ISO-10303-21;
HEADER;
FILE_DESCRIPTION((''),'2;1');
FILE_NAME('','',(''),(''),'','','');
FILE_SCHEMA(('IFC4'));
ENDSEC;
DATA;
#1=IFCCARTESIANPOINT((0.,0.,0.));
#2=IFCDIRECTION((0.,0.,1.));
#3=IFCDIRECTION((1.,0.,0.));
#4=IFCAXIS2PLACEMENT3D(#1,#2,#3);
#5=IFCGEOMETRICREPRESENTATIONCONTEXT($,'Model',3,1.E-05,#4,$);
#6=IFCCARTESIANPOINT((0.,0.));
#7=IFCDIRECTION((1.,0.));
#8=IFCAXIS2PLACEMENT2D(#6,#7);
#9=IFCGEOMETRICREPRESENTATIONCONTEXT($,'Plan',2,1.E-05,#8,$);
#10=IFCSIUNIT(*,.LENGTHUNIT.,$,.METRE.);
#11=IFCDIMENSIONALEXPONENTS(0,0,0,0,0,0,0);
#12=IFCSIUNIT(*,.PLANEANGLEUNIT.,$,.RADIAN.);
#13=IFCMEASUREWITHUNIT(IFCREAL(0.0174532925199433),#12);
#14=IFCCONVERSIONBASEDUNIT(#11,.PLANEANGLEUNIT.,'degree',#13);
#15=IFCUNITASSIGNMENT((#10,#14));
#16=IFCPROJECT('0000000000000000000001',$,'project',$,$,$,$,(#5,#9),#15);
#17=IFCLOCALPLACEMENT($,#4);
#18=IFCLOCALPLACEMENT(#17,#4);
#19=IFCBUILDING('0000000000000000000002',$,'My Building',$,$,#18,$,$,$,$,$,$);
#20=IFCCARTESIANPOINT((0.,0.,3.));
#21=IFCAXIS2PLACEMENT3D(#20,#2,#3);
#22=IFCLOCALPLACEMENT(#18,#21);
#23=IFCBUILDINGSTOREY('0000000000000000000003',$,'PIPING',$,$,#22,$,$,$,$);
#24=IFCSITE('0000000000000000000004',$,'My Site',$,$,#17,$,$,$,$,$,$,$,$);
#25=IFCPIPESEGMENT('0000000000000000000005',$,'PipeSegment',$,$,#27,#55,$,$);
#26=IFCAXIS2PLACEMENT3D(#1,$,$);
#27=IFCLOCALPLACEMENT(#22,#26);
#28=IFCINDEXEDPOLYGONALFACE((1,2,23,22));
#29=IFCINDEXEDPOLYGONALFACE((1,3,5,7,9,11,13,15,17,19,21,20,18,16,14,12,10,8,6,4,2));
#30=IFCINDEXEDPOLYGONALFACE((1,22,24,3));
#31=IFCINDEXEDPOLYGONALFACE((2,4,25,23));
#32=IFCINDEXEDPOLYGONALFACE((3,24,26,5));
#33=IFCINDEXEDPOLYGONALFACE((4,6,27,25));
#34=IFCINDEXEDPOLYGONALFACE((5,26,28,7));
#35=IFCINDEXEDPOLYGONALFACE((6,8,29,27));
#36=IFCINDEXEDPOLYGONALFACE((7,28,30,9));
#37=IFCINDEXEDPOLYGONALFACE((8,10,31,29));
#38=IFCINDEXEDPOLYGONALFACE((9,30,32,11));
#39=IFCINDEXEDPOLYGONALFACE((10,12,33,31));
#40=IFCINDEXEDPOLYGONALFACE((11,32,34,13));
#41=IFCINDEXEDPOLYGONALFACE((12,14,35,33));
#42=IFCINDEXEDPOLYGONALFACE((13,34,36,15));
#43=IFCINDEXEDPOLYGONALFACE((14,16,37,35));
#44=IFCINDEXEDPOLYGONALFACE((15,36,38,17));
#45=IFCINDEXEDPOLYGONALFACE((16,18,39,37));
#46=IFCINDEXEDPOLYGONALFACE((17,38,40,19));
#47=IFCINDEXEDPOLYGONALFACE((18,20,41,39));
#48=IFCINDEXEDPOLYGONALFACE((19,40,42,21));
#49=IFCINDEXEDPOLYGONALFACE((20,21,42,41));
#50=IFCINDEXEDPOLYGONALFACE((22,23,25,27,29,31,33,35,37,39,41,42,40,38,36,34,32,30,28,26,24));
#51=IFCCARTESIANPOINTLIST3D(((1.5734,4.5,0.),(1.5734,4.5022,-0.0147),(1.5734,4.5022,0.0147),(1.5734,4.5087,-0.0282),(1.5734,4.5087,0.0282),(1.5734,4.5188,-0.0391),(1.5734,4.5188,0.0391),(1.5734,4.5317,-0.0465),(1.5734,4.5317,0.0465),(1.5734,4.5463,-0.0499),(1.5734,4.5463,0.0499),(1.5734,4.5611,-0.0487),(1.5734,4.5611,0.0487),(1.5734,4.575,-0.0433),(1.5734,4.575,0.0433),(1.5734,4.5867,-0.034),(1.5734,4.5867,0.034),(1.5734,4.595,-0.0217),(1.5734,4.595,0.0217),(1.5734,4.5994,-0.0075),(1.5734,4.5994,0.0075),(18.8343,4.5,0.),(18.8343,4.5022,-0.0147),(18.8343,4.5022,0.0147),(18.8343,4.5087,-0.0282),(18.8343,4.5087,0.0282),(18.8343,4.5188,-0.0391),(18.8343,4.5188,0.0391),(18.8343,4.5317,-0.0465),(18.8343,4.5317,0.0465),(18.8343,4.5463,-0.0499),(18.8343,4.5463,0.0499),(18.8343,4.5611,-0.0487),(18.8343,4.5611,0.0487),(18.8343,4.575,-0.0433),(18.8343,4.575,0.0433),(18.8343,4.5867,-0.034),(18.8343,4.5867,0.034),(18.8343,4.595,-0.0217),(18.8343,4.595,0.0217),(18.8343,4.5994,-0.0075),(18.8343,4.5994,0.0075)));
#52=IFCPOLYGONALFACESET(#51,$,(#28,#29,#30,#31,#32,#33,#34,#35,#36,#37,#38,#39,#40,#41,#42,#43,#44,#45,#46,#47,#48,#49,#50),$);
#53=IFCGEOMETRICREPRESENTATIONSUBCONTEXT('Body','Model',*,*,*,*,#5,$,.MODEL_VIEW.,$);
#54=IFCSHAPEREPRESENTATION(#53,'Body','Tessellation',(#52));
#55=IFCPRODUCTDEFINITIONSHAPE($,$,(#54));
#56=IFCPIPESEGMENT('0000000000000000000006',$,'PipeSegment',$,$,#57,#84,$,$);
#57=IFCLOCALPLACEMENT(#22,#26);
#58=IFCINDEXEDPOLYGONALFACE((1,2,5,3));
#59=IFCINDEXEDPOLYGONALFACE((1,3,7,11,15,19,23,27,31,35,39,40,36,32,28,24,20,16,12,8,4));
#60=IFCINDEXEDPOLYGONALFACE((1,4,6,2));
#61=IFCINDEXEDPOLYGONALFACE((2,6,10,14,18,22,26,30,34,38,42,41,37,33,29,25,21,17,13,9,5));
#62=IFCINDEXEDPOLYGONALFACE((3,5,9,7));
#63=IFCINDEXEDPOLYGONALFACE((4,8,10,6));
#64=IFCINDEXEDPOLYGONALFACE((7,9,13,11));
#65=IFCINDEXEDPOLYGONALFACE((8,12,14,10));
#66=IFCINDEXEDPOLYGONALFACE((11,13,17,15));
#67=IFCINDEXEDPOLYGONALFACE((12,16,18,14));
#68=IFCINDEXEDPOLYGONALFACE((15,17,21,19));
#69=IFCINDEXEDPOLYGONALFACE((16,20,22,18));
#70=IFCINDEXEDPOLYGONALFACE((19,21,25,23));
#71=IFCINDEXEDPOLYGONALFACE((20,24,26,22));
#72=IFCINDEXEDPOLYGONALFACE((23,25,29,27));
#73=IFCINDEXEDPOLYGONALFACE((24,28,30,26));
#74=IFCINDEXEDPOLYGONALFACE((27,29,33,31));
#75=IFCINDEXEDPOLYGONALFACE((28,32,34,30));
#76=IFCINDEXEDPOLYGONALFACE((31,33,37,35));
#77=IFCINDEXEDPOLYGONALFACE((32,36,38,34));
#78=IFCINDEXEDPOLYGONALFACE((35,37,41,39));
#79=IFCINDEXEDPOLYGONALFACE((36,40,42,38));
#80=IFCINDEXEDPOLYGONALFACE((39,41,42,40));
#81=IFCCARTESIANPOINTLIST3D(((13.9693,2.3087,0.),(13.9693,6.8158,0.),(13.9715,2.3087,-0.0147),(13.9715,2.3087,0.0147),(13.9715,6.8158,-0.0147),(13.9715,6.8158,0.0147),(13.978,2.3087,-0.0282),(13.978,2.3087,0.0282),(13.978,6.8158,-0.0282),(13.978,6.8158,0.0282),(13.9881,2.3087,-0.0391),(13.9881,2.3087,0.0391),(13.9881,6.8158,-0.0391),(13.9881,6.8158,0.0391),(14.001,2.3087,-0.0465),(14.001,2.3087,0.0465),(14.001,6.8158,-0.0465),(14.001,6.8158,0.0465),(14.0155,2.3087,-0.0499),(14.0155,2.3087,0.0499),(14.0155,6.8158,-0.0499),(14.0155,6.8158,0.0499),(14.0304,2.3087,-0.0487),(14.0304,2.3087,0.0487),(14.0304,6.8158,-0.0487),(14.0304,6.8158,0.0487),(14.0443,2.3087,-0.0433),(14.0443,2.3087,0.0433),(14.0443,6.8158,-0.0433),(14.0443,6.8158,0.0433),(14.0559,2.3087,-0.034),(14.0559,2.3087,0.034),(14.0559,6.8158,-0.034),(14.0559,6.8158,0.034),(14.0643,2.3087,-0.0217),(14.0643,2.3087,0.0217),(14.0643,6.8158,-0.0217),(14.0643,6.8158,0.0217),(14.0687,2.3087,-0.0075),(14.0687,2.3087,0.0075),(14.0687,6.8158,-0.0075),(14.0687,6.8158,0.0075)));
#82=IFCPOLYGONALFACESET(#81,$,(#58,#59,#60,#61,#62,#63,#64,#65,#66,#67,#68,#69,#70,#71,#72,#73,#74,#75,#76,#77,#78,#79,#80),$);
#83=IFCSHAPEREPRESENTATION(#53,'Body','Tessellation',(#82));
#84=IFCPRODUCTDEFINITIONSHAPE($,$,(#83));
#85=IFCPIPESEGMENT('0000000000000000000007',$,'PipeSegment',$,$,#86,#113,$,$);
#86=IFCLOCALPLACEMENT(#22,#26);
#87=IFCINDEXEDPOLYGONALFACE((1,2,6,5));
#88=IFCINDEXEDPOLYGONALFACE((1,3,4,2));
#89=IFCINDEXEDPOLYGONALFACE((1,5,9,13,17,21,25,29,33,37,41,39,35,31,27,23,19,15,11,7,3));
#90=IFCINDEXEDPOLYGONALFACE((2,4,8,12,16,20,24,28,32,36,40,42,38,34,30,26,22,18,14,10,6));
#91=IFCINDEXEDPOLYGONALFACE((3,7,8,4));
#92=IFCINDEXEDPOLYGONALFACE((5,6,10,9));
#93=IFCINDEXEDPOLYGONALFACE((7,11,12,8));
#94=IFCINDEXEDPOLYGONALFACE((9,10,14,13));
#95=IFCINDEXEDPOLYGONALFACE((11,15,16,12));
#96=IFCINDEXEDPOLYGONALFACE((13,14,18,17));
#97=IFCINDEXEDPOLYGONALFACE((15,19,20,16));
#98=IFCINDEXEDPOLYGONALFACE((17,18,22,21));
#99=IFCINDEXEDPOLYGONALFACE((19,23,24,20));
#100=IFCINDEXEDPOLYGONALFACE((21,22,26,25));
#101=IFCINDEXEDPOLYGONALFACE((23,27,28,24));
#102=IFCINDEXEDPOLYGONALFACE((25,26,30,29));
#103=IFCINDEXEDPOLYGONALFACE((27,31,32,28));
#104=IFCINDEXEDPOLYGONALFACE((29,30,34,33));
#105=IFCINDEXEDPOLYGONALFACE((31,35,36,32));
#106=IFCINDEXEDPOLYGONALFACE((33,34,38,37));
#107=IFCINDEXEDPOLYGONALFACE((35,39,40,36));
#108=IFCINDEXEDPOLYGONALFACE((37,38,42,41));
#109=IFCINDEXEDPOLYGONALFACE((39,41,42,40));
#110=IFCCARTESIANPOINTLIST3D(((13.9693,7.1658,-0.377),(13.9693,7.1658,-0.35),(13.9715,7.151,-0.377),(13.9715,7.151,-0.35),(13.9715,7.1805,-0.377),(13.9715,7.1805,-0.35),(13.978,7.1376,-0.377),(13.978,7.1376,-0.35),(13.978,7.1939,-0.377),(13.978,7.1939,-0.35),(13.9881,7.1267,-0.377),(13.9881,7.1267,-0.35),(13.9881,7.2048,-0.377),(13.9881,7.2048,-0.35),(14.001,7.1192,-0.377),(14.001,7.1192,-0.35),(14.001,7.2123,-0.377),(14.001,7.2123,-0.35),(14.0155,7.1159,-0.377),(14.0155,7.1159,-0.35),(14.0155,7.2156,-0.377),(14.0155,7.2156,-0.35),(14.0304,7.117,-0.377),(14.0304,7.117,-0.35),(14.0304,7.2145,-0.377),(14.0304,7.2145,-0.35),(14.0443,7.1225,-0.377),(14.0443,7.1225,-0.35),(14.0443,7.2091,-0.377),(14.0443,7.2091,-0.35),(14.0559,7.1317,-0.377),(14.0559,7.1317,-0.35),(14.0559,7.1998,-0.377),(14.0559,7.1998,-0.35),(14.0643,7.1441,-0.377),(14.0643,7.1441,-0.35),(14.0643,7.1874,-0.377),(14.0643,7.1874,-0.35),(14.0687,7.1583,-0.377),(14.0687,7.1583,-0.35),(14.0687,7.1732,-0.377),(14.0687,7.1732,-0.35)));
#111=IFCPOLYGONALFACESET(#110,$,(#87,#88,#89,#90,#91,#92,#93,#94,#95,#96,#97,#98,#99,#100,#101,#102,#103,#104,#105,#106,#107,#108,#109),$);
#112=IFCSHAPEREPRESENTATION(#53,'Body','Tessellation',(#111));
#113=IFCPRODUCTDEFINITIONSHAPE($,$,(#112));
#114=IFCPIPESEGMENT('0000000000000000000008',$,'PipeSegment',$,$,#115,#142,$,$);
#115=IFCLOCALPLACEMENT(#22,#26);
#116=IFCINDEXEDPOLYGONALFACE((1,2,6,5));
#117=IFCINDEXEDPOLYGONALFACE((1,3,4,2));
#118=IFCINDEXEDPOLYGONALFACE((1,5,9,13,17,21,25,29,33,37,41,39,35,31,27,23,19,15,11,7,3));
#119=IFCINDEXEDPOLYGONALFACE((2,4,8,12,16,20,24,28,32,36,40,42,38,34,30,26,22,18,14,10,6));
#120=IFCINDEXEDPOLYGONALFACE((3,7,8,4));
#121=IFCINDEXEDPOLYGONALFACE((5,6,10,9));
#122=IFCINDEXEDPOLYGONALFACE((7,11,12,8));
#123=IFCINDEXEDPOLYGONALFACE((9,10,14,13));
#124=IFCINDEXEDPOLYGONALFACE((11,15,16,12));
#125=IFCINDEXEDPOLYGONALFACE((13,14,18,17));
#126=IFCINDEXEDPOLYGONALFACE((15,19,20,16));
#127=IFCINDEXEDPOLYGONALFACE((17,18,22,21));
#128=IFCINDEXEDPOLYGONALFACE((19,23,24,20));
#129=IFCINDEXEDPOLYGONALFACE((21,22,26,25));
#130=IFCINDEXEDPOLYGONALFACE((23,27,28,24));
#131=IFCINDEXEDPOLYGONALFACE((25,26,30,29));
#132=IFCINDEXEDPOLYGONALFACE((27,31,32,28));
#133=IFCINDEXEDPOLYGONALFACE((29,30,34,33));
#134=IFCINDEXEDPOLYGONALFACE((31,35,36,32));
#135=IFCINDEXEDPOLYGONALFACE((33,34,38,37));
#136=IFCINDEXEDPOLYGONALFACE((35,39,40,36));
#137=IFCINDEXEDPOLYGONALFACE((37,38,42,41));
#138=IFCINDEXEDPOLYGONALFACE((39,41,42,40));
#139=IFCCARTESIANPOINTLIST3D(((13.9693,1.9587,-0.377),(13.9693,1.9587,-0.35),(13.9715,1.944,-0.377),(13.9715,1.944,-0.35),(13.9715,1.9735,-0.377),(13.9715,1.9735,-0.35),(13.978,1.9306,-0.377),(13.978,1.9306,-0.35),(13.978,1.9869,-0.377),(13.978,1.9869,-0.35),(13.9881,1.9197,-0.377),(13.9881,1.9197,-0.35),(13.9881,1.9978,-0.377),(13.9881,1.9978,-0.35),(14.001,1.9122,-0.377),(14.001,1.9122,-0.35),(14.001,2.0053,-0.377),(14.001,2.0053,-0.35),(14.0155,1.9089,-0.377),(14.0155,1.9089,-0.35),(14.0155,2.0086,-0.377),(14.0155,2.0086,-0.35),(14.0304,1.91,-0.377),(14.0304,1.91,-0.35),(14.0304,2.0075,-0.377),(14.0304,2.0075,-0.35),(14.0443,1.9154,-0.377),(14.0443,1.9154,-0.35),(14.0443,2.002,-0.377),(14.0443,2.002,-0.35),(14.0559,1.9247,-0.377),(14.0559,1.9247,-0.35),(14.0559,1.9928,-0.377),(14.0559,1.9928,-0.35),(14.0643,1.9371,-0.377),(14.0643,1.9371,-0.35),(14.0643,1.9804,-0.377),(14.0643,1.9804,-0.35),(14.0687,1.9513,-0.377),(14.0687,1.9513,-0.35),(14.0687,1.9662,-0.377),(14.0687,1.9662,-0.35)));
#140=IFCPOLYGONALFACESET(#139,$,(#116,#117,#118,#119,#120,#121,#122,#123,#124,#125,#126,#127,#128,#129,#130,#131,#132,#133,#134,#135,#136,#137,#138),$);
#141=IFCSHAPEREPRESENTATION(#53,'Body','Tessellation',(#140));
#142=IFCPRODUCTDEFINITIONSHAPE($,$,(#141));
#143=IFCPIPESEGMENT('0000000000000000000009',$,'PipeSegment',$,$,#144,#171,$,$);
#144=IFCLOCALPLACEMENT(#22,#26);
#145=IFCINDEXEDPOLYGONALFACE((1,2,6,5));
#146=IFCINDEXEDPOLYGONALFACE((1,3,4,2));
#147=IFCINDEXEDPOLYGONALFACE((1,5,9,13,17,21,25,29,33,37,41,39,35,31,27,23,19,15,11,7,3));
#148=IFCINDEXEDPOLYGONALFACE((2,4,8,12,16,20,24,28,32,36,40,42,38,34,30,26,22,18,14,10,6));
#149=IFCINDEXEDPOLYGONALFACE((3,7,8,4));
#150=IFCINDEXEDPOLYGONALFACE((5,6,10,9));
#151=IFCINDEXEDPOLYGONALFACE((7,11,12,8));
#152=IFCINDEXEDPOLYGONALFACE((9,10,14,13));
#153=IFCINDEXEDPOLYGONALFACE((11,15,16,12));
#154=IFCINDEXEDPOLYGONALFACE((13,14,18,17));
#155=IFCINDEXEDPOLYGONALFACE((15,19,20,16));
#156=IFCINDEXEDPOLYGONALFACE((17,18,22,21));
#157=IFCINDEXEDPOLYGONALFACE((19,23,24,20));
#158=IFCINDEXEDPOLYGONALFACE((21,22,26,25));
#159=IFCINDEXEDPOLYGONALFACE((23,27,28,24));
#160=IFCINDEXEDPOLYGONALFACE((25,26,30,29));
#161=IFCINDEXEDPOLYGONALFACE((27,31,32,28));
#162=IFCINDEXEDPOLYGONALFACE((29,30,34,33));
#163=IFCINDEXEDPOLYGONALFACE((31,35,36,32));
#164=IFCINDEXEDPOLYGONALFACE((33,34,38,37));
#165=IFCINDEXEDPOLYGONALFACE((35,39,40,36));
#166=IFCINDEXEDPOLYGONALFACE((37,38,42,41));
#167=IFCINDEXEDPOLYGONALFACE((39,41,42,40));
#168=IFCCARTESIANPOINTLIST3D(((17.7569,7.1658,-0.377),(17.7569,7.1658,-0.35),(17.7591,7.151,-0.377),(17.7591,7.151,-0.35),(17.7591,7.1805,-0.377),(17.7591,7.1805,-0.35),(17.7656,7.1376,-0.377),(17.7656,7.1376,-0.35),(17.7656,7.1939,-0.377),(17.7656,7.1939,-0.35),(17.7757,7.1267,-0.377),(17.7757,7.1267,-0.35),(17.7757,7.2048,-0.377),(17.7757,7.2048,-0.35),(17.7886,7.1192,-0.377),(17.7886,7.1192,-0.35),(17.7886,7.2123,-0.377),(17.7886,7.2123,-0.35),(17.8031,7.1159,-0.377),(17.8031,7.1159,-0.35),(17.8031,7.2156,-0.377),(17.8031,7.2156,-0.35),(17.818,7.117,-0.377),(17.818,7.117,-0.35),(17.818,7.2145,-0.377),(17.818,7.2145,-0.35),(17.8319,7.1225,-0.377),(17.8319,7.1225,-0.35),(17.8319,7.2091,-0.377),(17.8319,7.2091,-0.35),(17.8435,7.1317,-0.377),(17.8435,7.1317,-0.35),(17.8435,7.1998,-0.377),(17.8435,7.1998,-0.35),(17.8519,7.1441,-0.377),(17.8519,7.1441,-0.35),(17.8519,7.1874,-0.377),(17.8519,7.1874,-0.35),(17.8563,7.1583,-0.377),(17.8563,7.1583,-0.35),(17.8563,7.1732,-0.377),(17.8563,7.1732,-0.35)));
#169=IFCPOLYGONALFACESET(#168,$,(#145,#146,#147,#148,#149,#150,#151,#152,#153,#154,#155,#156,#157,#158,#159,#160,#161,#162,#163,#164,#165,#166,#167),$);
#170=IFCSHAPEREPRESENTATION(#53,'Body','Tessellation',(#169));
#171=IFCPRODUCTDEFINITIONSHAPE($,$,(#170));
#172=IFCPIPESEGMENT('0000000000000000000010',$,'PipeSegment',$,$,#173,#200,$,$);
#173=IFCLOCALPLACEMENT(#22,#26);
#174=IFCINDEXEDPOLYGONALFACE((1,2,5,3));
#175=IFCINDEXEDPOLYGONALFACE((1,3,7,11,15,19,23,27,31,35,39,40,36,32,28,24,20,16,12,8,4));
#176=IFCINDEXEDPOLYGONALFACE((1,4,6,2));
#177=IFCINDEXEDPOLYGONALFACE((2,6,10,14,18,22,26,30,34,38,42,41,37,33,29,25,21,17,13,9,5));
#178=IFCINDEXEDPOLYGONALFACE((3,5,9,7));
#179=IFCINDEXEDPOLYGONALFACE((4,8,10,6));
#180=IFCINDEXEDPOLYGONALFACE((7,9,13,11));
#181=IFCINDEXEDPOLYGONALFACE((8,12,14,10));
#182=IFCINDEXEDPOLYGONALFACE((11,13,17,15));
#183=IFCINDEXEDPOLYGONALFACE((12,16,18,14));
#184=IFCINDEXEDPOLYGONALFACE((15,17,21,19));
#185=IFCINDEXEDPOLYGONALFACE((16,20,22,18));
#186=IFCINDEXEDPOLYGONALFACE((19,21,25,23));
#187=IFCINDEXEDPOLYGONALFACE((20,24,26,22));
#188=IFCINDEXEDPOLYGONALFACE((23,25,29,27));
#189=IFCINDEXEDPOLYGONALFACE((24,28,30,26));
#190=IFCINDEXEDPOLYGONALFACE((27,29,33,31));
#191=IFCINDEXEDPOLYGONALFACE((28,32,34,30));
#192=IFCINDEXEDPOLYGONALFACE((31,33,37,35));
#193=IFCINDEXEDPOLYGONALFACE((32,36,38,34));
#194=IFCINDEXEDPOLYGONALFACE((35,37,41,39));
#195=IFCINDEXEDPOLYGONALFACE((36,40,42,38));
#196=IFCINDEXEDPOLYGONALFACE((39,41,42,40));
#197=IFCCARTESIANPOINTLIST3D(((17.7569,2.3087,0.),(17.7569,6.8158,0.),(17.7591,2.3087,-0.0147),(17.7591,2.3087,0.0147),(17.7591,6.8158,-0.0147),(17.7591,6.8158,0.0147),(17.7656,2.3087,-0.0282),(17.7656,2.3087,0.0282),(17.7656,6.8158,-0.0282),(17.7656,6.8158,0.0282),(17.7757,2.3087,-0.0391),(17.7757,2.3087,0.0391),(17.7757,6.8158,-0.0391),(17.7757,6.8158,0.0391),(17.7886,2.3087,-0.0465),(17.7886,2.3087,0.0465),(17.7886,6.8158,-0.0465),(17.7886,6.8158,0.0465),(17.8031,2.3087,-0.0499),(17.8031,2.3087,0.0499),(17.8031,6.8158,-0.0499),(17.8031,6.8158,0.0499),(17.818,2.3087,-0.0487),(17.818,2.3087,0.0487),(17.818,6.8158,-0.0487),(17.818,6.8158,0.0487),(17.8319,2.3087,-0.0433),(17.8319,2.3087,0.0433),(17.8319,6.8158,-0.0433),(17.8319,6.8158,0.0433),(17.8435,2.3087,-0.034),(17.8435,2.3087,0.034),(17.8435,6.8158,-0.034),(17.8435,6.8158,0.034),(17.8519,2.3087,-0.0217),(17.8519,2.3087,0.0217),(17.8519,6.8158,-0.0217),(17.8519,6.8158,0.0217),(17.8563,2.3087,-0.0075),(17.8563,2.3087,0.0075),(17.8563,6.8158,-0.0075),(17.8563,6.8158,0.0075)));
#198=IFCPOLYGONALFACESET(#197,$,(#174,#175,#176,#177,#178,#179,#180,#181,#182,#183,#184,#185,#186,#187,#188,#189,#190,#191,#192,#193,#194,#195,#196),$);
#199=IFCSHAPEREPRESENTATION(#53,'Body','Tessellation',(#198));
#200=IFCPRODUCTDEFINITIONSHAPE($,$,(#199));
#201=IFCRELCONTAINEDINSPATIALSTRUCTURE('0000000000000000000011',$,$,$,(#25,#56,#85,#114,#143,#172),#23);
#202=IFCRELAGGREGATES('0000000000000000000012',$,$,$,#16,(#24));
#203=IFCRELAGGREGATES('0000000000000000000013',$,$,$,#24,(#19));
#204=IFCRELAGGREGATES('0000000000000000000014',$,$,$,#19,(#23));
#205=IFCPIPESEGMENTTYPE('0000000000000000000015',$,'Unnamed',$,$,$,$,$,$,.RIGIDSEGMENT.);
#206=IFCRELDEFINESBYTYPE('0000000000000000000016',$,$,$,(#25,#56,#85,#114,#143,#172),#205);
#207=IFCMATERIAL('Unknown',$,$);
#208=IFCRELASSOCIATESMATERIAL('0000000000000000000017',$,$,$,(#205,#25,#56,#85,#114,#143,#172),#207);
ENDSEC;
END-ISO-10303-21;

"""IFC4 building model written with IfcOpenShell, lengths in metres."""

from ifc_helpers import new_model, entity, si_unit, converted_unit, frame, origin_with_axes, origin_2d_with_axis, place, context, subcontext, project, spatial, circle, extrude, material, material_profile, profile_set, profile_usage, type_object, element, save


model = new_model("IFC4")

# Units and contexts
model_context = context("Model", 3, precision=1e-05, world=origin_with_axes())
plan_context = context("Plan", 2, precision=1e-05, world=origin_2d_with_axis())
body_context = subcontext(model_context, "Body", "Model", "MODEL_VIEW")
ifc_project = project(units=[si_unit("LENGTHUNIT", "METRE"), converted_unit("PLANEANGLEUNIT", "degree", entity("IfcReal", 0.0174532925199433), si_unit("PLANEANGLEUNIT", "RADIAN"), dimensions=[0, 0, 0, 0, 0, 0, 0])], contexts=[model_context, plan_context])

# Site, building, storey
site_placement = place(None, origin_with_axes())
site = spatial("IfcSite", under=ifc_project, at=site_placement, Name="My Site")
building_placement = place(site_placement, origin_with_axes())
building = spatial("IfcBuilding", under=site, at=building_placement, Name="My Building")
storey_placement = place(building_placement, frame((0.0, 0.0, 3.0), z_axis=(0.0, 0.0, 1.0), x_axis=(1.0, 0.0, 0.0)))
storey = spatial("IfcBuildingStorey", under=building, at=storey_placement, Name="PIPING")

# Pipe segments
ifc_material = material(Name="Unknown")
ifc_material_profile = material_profile(ifc_material, circle(Radius=0.05))
ifc_profile_set = profile_set([ifc_material_profile])
ifc_profile_usage_1 = profile_usage(ifc_profile_set, cardinal=5)
pipe_segment_type = type_object("IfcPipeSegmentType", Name="Unnamed", PredefinedType="RIGIDSEGMENT", material=ifc_profile_set)
pipe_segment_1_placement = place(storey_placement, frame((18.8343, 4.55, 0.0), z_axis=(-1.0, 0.0, 0.0), x_axis=(0.0, -1.0, 0.0)))
element("IfcPipeSegment", 1, at=pipe_segment_1_placement, inside=storey, type_object=pipe_segment_type, material=ifc_profile_usage_1, Name="PipeSegment", context=body_context, shape_type="SweptSolid", body=[
    extrude(circle(Radius=0.05), origin_with_axes(), (0.0, 0.0, 1.0), 17.2609),
])
ifc_profile_usage_2 = profile_usage(ifc_profile_set, cardinal=5)
pipe_segment_2_placement = place(storey_placement, frame((14.0193, 2.3087, 0.0), z_axis=(0.0, 1.0, 0.0), x_axis=(-1.0, 0.0, 0.0)))
element("IfcPipeSegment", 2, at=pipe_segment_2_placement, inside=storey, type_object=pipe_segment_type, material=ifc_profile_usage_2, Name="PipeSegment", context=body_context, shape_type="SweptSolid", body=[
    extrude(circle(Radius=0.05), origin_with_axes(), (0.0, 0.0, 1.0), 4.507),
])
ifc_profile_usage_3 = profile_usage(ifc_profile_set, cardinal=5)
pipe_segment_3_placement = place(storey_placement, frame((14.0193, 7.1658, -0.35), z_axis=(0.0, 0.0, -1.0), x_axis=(-1.0, 0.0, 0.0)))
element("IfcPipeSegment", 3, at=pipe_segment_3_placement, inside=storey, type_object=pipe_segment_type, material=ifc_profile_usage_3, Name="PipeSegment", context=body_context, shape_type="SweptSolid", body=[
    extrude(circle(Radius=0.05), origin_with_axes(), (0.0, 0.0, 1.0), 0.027),
])
ifc_profile_usage_4 = profile_usage(ifc_profile_set, cardinal=5)
pipe_segment_4_placement = place(storey_placement, frame((14.0193, 1.9587, -0.35), z_axis=(0.0, 0.0, -1.0), x_axis=(-1.0, 0.0, 0.0)))
element("IfcPipeSegment", 4, at=pipe_segment_4_placement, inside=storey, type_object=pipe_segment_type, material=ifc_profile_usage_4, Name="PipeSegment", context=body_context, shape_type="SweptSolid", body=[
    extrude(circle(Radius=0.05), origin_with_axes(), (0.0, 0.0, 1.0), 0.027),
])
ifc_profile_usage_5 = profile_usage(ifc_profile_set, cardinal=5)
pipe_segment_5_placement = place(storey_placement, frame((17.8069, 7.1658, -0.35), z_axis=(0.0, 0.0, -1.0), x_axis=(-1.0, 0.0, 0.0)))
element("IfcPipeSegment", 5, at=pipe_segment_5_placement, inside=storey, type_object=pipe_segment_type, material=ifc_profile_usage_5, Name="PipeSegment", context=body_context, shape_type="SweptSolid", body=[
    extrude(circle(Radius=0.05), origin_with_axes(), (0.0, 0.0, 1.0), 0.027),
])
ifc_profile_usage_6 = profile_usage(ifc_profile_set, cardinal=5)
pipe_segment_6_placement = place(storey_placement, frame((17.8069, 2.3087, 0.0), z_axis=(0.0, 1.0, 0.0), x_axis=(-1.0, 0.0, 0.0)))
element("IfcPipeSegment", 6, at=pipe_segment_6_placement, inside=storey, type_object=pipe_segment_type, material=ifc_profile_usage_6, Name="PipeSegment", context=body_context, shape_type="SweptSolid", body=[
    extrude(circle(Radius=0.05), origin_with_axes(), (0.0, 0.0, 1.0), 4.507),
])

save(model, "model.ifc")
